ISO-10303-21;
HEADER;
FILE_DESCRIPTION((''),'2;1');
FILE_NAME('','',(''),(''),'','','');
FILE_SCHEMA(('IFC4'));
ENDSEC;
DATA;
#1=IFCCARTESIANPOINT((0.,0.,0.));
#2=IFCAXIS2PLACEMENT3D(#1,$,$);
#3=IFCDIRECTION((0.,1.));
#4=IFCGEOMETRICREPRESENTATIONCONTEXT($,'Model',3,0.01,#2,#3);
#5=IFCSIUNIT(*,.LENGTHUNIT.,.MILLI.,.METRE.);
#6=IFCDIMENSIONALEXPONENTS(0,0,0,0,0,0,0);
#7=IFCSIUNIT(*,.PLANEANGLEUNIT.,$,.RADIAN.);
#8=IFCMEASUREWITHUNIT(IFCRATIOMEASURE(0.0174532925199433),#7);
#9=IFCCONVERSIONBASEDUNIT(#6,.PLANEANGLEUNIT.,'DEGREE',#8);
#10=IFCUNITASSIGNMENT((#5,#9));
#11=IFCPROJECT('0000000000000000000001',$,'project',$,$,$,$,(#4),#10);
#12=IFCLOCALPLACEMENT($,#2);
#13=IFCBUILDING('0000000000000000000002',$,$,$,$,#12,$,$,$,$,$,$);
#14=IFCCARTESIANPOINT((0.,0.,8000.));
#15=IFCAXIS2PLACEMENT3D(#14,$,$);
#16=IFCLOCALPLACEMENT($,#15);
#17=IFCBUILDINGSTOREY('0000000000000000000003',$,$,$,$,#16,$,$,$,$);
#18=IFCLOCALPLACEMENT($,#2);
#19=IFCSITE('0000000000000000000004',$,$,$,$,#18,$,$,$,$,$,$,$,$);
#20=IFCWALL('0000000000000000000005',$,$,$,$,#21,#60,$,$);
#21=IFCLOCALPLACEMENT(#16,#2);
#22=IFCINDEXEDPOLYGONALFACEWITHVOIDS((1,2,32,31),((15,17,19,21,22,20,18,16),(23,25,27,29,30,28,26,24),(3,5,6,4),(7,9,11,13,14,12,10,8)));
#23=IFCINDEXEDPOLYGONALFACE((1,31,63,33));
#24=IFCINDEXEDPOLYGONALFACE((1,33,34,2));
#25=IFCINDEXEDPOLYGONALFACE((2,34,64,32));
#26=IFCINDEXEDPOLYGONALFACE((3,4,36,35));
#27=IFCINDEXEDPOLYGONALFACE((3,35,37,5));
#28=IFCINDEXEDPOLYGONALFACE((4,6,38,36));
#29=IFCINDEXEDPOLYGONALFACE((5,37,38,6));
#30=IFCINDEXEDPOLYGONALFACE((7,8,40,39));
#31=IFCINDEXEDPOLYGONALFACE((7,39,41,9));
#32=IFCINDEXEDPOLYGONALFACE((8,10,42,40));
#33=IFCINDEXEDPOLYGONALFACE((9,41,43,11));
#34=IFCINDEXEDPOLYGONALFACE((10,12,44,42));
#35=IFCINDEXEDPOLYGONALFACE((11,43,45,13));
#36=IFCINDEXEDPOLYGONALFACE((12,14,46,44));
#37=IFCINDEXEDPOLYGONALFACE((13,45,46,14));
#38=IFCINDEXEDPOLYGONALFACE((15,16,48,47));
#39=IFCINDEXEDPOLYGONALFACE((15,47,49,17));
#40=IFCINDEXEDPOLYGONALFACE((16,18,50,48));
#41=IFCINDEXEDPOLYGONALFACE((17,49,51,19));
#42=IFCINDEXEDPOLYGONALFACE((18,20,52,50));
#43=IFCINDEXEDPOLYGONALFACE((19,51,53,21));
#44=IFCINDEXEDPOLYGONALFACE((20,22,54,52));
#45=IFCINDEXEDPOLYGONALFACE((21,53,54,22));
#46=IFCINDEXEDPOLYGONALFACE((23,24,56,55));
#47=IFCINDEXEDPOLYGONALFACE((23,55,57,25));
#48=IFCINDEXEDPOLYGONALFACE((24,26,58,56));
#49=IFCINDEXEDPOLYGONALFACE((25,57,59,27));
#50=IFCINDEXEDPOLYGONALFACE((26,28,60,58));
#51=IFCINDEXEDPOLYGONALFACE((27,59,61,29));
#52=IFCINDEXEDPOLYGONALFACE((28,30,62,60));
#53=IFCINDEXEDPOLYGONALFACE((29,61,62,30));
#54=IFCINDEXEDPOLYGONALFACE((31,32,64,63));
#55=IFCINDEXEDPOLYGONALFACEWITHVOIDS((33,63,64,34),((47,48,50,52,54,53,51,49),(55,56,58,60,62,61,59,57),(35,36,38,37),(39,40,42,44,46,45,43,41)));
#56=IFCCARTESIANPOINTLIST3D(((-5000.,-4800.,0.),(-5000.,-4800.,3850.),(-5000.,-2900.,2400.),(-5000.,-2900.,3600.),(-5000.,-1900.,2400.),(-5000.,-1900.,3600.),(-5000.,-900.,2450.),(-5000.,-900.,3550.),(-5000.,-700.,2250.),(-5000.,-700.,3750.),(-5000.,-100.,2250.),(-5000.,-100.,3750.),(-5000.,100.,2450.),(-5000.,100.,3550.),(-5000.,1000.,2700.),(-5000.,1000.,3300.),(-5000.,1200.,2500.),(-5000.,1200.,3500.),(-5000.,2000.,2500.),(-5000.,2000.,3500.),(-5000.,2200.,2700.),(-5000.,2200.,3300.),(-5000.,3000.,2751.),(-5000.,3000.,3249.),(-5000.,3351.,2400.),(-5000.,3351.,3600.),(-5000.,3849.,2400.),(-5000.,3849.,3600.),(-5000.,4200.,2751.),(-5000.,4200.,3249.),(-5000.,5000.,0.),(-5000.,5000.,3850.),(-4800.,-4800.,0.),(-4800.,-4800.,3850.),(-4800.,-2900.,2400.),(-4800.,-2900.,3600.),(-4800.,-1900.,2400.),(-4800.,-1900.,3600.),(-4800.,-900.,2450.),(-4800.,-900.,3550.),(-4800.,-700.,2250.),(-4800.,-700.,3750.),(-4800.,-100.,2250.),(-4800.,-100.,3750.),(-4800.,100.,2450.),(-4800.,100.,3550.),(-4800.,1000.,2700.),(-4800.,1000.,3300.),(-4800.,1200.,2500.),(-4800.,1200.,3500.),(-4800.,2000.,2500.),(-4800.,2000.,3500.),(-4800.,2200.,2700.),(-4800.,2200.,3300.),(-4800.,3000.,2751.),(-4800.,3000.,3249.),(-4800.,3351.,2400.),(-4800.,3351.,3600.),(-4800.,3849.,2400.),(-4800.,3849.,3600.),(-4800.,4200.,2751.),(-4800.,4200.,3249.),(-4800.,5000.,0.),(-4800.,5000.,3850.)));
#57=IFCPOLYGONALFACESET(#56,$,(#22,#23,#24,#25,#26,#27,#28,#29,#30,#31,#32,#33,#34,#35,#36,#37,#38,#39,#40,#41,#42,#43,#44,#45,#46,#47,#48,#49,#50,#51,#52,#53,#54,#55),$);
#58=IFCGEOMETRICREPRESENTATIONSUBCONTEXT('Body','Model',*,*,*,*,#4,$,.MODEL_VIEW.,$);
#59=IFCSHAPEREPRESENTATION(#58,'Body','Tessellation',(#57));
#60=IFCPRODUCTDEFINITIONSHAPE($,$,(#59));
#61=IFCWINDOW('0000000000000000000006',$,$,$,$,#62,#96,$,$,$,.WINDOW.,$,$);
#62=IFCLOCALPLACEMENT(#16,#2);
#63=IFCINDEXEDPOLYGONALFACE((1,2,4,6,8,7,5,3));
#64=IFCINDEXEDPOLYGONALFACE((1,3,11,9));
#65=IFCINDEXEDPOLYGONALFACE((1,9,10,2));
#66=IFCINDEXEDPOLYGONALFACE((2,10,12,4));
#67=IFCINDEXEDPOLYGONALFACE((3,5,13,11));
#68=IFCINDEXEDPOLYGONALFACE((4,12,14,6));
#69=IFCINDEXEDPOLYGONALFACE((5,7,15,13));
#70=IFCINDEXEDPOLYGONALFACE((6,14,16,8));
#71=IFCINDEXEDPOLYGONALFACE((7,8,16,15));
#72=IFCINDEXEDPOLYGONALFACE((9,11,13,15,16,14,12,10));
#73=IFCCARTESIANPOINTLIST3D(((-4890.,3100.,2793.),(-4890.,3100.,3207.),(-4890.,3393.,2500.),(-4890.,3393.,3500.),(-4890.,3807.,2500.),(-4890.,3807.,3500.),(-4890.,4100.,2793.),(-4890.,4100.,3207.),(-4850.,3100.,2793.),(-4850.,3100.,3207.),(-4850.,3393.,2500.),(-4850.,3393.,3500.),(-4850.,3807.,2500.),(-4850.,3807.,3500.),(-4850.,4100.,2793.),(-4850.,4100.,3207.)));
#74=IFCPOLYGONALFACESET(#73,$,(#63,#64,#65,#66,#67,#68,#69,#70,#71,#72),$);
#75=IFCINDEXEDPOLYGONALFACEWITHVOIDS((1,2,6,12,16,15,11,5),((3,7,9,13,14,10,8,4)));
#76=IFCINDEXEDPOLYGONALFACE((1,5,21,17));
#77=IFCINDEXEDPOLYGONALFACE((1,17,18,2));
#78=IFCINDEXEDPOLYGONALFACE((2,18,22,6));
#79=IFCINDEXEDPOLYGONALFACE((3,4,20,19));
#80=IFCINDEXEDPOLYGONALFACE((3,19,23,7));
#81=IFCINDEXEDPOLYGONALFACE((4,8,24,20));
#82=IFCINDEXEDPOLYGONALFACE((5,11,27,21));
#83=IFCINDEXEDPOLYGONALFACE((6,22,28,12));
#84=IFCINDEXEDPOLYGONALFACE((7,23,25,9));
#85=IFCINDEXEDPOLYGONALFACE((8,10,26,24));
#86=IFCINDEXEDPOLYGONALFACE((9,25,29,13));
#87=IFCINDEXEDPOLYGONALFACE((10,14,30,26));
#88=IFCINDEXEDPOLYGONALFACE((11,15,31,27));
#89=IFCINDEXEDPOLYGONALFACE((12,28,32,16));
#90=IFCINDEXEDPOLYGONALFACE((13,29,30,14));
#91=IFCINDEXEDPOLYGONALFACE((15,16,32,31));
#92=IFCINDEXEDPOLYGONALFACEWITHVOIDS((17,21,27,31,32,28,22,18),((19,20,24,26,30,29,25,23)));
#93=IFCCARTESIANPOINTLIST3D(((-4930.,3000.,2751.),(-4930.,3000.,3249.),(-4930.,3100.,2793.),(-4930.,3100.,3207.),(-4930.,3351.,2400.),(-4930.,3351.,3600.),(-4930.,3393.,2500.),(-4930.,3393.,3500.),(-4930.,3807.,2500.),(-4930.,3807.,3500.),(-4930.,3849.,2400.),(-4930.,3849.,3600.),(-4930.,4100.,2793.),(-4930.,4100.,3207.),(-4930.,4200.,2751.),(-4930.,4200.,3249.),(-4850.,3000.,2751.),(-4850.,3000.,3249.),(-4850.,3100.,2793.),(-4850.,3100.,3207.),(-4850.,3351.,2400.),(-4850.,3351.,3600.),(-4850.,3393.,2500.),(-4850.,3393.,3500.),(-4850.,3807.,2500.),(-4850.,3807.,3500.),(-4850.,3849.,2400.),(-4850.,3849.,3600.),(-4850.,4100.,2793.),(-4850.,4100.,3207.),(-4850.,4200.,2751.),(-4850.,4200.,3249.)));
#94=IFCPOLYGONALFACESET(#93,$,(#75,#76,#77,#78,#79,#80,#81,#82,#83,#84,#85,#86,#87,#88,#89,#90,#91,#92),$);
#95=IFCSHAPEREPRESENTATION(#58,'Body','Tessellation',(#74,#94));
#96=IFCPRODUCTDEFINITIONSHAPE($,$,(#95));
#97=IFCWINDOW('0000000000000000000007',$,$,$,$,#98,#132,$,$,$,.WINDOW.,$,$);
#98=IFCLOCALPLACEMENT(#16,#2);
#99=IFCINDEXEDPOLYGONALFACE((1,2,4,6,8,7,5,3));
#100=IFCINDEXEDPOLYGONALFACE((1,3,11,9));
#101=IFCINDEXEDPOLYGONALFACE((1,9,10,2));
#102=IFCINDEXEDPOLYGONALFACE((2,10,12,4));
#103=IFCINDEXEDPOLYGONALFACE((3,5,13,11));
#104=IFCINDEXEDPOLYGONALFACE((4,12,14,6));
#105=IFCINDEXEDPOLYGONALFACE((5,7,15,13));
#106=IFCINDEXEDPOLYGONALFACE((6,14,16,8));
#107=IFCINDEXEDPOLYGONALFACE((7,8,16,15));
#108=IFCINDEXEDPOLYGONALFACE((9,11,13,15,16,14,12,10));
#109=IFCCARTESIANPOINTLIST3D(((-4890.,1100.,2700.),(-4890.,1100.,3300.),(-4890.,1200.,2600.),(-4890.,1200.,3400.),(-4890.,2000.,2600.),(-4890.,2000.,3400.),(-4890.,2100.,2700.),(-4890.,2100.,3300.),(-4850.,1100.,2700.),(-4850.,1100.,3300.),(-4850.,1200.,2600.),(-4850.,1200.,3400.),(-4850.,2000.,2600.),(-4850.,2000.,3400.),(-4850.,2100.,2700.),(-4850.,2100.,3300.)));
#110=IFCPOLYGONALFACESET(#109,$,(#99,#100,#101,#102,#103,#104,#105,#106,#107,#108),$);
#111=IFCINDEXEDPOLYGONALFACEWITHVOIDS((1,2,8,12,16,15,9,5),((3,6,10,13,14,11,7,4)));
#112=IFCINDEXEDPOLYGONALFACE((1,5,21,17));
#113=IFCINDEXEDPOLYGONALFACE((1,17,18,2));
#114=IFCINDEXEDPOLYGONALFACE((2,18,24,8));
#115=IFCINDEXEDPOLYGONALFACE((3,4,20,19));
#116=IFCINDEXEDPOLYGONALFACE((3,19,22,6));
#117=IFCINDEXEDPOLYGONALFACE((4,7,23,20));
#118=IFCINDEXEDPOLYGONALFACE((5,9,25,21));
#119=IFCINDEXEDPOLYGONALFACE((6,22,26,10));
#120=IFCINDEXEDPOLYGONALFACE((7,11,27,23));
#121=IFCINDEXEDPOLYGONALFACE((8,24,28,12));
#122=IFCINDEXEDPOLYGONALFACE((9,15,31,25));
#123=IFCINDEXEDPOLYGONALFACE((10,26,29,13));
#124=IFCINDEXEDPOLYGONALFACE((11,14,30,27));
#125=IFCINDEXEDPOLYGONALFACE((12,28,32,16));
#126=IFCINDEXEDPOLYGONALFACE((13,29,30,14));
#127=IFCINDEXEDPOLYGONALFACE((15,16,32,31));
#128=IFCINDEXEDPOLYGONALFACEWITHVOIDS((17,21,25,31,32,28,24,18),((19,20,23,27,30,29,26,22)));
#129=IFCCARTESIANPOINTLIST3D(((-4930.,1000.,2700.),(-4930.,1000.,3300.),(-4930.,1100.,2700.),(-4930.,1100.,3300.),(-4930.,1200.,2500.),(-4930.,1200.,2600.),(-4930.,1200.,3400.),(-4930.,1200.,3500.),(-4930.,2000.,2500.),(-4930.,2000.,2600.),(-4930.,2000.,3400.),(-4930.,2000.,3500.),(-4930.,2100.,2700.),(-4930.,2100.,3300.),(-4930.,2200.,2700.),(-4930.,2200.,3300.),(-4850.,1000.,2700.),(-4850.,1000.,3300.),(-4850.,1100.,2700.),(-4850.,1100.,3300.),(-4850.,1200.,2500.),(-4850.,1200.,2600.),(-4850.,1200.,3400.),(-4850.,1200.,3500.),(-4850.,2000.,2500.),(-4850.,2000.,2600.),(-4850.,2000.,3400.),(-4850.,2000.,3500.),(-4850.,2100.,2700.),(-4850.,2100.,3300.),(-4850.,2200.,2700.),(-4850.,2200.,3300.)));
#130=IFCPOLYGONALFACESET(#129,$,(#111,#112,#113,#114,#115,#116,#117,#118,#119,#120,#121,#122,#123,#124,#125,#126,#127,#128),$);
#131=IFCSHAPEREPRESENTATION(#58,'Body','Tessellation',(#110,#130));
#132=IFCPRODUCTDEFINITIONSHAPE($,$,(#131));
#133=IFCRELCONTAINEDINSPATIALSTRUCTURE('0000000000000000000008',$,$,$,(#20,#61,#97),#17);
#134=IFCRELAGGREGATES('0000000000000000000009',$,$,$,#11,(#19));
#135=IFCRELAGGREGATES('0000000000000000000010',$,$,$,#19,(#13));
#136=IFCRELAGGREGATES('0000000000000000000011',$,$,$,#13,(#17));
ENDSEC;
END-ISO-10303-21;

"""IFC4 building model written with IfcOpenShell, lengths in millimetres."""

from ifc_helpers import new_model, entity, si_unit, converted_unit, direction, frame, origin, origin_2d, place, context, subcontext, project, spatial, polyline, rectangle, outline, extrude, element, save


model = new_model("IFC4")

# Units and contexts
model_context = context("Model", 3, precision=0.01, world=origin(), true_north=direction((0.0, 1.0)))
body_context = subcontext(model_context, "Body", "Model", "MODEL_VIEW")
ifc_project = project(units=[si_unit("LENGTHUNIT", "METRE", prefix="MILLI"), converted_unit("PLANEANGLEUNIT", "DEGREE", entity("IfcRatioMeasure", 0.0174532925199433), si_unit("PLANEANGLEUNIT", "RADIAN"), dimensions=[0, 0, 0, 0, 0, 0, 0])], contexts=[model_context])

# Site, building, storey
site_placement = place(None, origin())
site = spatial("IfcSite", under=ifc_project, at=site_placement)
building_placement = place(None, origin())
building = spatial("IfcBuilding", under=site, at=building_placement)
storey_placement = place(None, frame((0.0, 0.0, 8000.0)))
storey = spatial("IfcBuildingStorey", under=building, at=storey_placement)

# Shared definitions
cartesian_point_1 = entity("IfcCartesianPoint", [-500.0, -207.0])
shared_polyline_1 = entity("IfcPolyline", [cartesian_point_1, entity("IfcCartesianPoint", [-500.0, 207.0]), entity("IfcCartesianPoint", [-207.0, 500.0]), entity("IfcCartesianPoint", [207.0, 500.0]), entity("IfcCartesianPoint", [500.0, 207.0]), entity("IfcCartesianPoint", [500.0, -207.0]), entity("IfcCartesianPoint", [207.0, -500.0]), entity("IfcCartesianPoint", [-207.0, -500.0]), cartesian_point_1])
cartesian_point_2 = entity("IfcCartesianPoint", [-500.0, -300.0])
shared_polyline_2 = entity("IfcPolyline", [cartesian_point_2, entity("IfcCartesianPoint", [-500.0, 300.0]), entity("IfcCartesianPoint", [-400.0, 400.0]), entity("IfcCartesianPoint", [400.0, 400.0]), entity("IfcCartesianPoint", [500.0, 300.0]), entity("IfcCartesianPoint", [500.0, -300.0]), entity("IfcCartesianPoint", [400.0, -400.0]), entity("IfcCartesianPoint", [-400.0, -400.0]), cartesian_point_2])

# Wall, openings
wall_1_placement = place(storey_placement, frame((-4900.0, 100.0, 0.0), z_axis=(0.0, 0.0, 1.0), x_axis=(0.0, -1.0, 0.0)))
wall_1 = element("IfcWall", 1, at=wall_1_placement, inside=storey, context=body_context, shape_type="SweptSolid", body=[
    extrude(rectangle(XDim=9800.0, YDim=200.0, at=origin_2d()), origin(), (0.0, 0.0, 1.0), 3850.0),
])
window_1_placement = place(wall_1_placement, frame((-3500.0, 50.0, 3000.0)))
opening_1_placement = place(window_1_placement, frame((0.0, 50.0, 0.0)))
element("IfcOpeningElement", 2, at=opening_1_placement, cuts=wall_1, context=body_context, shape_type="SweptSolid", body=[
    extrude(outline(polyline([(-600.0, -249.0), (-600.0, 249.0), (-249.0, 600.0), (249.0, 600.0), (600.0, 249.0), (600.0, -249.0), (249.0, -600.0), (-249.0, -600.0), (-600.0, -249.0)])), frame((0.0, 0.0, 0.0), z_axis=(0.0, -1.0, 0.0), x_axis=(1.0, 0.0, 0.0)), (0.0, 0.0, 1.0), 200.0),
])
window_2_placement = place(wall_1_placement, frame((-1500.0, 50.0, 3000.0)))
opening_2_placement = place(window_2_placement, frame((0.0, 50.0, 0.0)))
element("IfcOpeningElement", 3, at=opening_2_placement, cuts=wall_1, context=body_context, shape_type="SweptSolid", body=[
    extrude(outline(polyline([(-600.0, -300.0), (-600.0, 300.0), (-400.0, 500.0), (400.0, 500.0), (600.0, 300.0), (600.0, -300.0), (400.0, -500.0), (-400.0, -500.0), (-600.0, -300.0)])), frame((0.0, 0.0, 0.0), z_axis=(0.0, -1.0, 0.0), x_axis=(1.0, 0.0, 0.0)), (0.0, 0.0, 1.0), 200.0),
])
window_3_placement = place(wall_1_placement, frame((500.0, 50.0, 3000.0)))
opening_3_placement = place(window_3_placement, frame((0.0, 50.0, 0.0)))
element("IfcOpeningElement", 4, at=opening_3_placement, cuts=wall_1, context=body_context, shape_type="SweptSolid", body=[
    extrude(outline(polyline([(-500.0, -550.0), (-500.0, 550.0), (-300.0, 750.0), (300.0, 750.0), (500.0, 550.0), (500.0, -550.0), (300.0, -750.0), (-300.0, -750.0), (-500.0, -550.0)])), frame((0.0, 0.0, 0.0), z_axis=(0.0, -1.0, 0.0), x_axis=(1.0, 0.0, 0.0)), (0.0, 0.0, 1.0), 200.0),
])
window_4_placement = place(wall_1_placement, frame((2500.0, 50.0, 3000.0)))
opening_4_placement = place(window_4_placement, frame((0.0, 50.0, 0.0)))
element("IfcOpeningElement", 5, at=opening_4_placement, cuts=wall_1, context=body_context, shape_type="SweptSolid", body=[
    extrude(outline(polyline([(-500.0, -600.0), (-500.0, 600.0), (-500.0, 600.0), (500.0, 600.0), (500.0, 600.0), (500.0, -600.0), (500.0, -600.0), (-500.0, -600.0), (-500.0, -600.0)])), frame((0.0, 0.0, 0.0), z_axis=(0.0, -1.0, 0.0), x_axis=(1.0, 0.0, 0.0)), (0.0, 0.0, 1.0), 200.0),
])

# Windows
cartesian_point_3 = entity("IfcCartesianPoint", [-600.0, -249.0])
element("IfcWindow", 6, at=window_1_placement, inside=storey, PredefinedType="WINDOW", context=body_context, shape_type="SweptSolid", body=[
    entity("IfcExtrudedAreaSolid", entity("IfcArbitraryClosedProfileDef", "AREA", None, shared_polyline_1), entity("IfcAxis2Placement3D", entity("IfcCartesianPoint", [0.0, 0.0, 0.0]), entity("IfcDirection", [0.0, -1.0, 0.0]), entity("IfcDirection", [1.0, 0.0, 0.0])), entity("IfcDirection", [0.0, 0.0, 1.0]), 40.0),
    entity("IfcExtrudedAreaSolid", entity("IfcArbitraryProfileDefWithVoids", "AREA", None, entity("IfcPolyline", [cartesian_point_3, entity("IfcCartesianPoint", [-600.0, 249.0]), entity("IfcCartesianPoint", [-249.0, 600.0]), entity("IfcCartesianPoint", [249.0, 600.0]), entity("IfcCartesianPoint", [600.0, 249.0]), entity("IfcCartesianPoint", [600.0, -249.0]), entity("IfcCartesianPoint", [249.0, -600.0]), entity("IfcCartesianPoint", [-249.0, -600.0]), cartesian_point_3]), [shared_polyline_1]), entity("IfcAxis2Placement3D", entity("IfcCartesianPoint", [0.0, 0.0, 0.0]), entity("IfcDirection", [0.0, -1.0, 0.0]), entity("IfcDirection", [1.0, 0.0, 0.0])), entity("IfcDirection", [0.0, 0.0, 1.0]), 80.0),
])
cartesian_point_4 = entity("IfcCartesianPoint", [-600.0, -300.0])
element("IfcWindow", 7, at=window_2_placement, inside=storey, PredefinedType="WINDOW", context=body_context, shape_type="SweptSolid", body=[
    entity("IfcExtrudedAreaSolid", entity("IfcArbitraryClosedProfileDef", "AREA", None, shared_polyline_2), entity("IfcAxis2Placement3D", entity("IfcCartesianPoint", [0.0, 0.0, 0.0]), entity("IfcDirection", [0.0, -1.0, 0.0]), entity("IfcDirection", [1.0, 0.0, 0.0])), entity("IfcDirection", [0.0, 0.0, 1.0]), 40.0),
    entity("IfcExtrudedAreaSolid", entity("IfcArbitraryProfileDefWithVoids", "AREA", None, entity("IfcPolyline", [cartesian_point_4, entity("IfcCartesianPoint", [-600.0, 300.0]), entity("IfcCartesianPoint", [-400.0, 500.0]), entity("IfcCartesianPoint", [400.0, 500.0]), entity("IfcCartesianPoint", [600.0, 300.0]), entity("IfcCartesianPoint", [600.0, -300.0]), entity("IfcCartesianPoint", [400.0, -500.0]), entity("IfcCartesianPoint", [-400.0, -500.0]), cartesian_point_4]), [shared_polyline_2]), entity("IfcAxis2Placement3D", entity("IfcCartesianPoint", [0.0, 0.0, 0.0]), entity("IfcDirection", [0.0, -1.0, 0.0]), entity("IfcDirection", [1.0, 0.0, 0.0])), entity("IfcDirection", [0.0, 0.0, 1.0]), 80.0),
])

save(model, "model.ifc")
